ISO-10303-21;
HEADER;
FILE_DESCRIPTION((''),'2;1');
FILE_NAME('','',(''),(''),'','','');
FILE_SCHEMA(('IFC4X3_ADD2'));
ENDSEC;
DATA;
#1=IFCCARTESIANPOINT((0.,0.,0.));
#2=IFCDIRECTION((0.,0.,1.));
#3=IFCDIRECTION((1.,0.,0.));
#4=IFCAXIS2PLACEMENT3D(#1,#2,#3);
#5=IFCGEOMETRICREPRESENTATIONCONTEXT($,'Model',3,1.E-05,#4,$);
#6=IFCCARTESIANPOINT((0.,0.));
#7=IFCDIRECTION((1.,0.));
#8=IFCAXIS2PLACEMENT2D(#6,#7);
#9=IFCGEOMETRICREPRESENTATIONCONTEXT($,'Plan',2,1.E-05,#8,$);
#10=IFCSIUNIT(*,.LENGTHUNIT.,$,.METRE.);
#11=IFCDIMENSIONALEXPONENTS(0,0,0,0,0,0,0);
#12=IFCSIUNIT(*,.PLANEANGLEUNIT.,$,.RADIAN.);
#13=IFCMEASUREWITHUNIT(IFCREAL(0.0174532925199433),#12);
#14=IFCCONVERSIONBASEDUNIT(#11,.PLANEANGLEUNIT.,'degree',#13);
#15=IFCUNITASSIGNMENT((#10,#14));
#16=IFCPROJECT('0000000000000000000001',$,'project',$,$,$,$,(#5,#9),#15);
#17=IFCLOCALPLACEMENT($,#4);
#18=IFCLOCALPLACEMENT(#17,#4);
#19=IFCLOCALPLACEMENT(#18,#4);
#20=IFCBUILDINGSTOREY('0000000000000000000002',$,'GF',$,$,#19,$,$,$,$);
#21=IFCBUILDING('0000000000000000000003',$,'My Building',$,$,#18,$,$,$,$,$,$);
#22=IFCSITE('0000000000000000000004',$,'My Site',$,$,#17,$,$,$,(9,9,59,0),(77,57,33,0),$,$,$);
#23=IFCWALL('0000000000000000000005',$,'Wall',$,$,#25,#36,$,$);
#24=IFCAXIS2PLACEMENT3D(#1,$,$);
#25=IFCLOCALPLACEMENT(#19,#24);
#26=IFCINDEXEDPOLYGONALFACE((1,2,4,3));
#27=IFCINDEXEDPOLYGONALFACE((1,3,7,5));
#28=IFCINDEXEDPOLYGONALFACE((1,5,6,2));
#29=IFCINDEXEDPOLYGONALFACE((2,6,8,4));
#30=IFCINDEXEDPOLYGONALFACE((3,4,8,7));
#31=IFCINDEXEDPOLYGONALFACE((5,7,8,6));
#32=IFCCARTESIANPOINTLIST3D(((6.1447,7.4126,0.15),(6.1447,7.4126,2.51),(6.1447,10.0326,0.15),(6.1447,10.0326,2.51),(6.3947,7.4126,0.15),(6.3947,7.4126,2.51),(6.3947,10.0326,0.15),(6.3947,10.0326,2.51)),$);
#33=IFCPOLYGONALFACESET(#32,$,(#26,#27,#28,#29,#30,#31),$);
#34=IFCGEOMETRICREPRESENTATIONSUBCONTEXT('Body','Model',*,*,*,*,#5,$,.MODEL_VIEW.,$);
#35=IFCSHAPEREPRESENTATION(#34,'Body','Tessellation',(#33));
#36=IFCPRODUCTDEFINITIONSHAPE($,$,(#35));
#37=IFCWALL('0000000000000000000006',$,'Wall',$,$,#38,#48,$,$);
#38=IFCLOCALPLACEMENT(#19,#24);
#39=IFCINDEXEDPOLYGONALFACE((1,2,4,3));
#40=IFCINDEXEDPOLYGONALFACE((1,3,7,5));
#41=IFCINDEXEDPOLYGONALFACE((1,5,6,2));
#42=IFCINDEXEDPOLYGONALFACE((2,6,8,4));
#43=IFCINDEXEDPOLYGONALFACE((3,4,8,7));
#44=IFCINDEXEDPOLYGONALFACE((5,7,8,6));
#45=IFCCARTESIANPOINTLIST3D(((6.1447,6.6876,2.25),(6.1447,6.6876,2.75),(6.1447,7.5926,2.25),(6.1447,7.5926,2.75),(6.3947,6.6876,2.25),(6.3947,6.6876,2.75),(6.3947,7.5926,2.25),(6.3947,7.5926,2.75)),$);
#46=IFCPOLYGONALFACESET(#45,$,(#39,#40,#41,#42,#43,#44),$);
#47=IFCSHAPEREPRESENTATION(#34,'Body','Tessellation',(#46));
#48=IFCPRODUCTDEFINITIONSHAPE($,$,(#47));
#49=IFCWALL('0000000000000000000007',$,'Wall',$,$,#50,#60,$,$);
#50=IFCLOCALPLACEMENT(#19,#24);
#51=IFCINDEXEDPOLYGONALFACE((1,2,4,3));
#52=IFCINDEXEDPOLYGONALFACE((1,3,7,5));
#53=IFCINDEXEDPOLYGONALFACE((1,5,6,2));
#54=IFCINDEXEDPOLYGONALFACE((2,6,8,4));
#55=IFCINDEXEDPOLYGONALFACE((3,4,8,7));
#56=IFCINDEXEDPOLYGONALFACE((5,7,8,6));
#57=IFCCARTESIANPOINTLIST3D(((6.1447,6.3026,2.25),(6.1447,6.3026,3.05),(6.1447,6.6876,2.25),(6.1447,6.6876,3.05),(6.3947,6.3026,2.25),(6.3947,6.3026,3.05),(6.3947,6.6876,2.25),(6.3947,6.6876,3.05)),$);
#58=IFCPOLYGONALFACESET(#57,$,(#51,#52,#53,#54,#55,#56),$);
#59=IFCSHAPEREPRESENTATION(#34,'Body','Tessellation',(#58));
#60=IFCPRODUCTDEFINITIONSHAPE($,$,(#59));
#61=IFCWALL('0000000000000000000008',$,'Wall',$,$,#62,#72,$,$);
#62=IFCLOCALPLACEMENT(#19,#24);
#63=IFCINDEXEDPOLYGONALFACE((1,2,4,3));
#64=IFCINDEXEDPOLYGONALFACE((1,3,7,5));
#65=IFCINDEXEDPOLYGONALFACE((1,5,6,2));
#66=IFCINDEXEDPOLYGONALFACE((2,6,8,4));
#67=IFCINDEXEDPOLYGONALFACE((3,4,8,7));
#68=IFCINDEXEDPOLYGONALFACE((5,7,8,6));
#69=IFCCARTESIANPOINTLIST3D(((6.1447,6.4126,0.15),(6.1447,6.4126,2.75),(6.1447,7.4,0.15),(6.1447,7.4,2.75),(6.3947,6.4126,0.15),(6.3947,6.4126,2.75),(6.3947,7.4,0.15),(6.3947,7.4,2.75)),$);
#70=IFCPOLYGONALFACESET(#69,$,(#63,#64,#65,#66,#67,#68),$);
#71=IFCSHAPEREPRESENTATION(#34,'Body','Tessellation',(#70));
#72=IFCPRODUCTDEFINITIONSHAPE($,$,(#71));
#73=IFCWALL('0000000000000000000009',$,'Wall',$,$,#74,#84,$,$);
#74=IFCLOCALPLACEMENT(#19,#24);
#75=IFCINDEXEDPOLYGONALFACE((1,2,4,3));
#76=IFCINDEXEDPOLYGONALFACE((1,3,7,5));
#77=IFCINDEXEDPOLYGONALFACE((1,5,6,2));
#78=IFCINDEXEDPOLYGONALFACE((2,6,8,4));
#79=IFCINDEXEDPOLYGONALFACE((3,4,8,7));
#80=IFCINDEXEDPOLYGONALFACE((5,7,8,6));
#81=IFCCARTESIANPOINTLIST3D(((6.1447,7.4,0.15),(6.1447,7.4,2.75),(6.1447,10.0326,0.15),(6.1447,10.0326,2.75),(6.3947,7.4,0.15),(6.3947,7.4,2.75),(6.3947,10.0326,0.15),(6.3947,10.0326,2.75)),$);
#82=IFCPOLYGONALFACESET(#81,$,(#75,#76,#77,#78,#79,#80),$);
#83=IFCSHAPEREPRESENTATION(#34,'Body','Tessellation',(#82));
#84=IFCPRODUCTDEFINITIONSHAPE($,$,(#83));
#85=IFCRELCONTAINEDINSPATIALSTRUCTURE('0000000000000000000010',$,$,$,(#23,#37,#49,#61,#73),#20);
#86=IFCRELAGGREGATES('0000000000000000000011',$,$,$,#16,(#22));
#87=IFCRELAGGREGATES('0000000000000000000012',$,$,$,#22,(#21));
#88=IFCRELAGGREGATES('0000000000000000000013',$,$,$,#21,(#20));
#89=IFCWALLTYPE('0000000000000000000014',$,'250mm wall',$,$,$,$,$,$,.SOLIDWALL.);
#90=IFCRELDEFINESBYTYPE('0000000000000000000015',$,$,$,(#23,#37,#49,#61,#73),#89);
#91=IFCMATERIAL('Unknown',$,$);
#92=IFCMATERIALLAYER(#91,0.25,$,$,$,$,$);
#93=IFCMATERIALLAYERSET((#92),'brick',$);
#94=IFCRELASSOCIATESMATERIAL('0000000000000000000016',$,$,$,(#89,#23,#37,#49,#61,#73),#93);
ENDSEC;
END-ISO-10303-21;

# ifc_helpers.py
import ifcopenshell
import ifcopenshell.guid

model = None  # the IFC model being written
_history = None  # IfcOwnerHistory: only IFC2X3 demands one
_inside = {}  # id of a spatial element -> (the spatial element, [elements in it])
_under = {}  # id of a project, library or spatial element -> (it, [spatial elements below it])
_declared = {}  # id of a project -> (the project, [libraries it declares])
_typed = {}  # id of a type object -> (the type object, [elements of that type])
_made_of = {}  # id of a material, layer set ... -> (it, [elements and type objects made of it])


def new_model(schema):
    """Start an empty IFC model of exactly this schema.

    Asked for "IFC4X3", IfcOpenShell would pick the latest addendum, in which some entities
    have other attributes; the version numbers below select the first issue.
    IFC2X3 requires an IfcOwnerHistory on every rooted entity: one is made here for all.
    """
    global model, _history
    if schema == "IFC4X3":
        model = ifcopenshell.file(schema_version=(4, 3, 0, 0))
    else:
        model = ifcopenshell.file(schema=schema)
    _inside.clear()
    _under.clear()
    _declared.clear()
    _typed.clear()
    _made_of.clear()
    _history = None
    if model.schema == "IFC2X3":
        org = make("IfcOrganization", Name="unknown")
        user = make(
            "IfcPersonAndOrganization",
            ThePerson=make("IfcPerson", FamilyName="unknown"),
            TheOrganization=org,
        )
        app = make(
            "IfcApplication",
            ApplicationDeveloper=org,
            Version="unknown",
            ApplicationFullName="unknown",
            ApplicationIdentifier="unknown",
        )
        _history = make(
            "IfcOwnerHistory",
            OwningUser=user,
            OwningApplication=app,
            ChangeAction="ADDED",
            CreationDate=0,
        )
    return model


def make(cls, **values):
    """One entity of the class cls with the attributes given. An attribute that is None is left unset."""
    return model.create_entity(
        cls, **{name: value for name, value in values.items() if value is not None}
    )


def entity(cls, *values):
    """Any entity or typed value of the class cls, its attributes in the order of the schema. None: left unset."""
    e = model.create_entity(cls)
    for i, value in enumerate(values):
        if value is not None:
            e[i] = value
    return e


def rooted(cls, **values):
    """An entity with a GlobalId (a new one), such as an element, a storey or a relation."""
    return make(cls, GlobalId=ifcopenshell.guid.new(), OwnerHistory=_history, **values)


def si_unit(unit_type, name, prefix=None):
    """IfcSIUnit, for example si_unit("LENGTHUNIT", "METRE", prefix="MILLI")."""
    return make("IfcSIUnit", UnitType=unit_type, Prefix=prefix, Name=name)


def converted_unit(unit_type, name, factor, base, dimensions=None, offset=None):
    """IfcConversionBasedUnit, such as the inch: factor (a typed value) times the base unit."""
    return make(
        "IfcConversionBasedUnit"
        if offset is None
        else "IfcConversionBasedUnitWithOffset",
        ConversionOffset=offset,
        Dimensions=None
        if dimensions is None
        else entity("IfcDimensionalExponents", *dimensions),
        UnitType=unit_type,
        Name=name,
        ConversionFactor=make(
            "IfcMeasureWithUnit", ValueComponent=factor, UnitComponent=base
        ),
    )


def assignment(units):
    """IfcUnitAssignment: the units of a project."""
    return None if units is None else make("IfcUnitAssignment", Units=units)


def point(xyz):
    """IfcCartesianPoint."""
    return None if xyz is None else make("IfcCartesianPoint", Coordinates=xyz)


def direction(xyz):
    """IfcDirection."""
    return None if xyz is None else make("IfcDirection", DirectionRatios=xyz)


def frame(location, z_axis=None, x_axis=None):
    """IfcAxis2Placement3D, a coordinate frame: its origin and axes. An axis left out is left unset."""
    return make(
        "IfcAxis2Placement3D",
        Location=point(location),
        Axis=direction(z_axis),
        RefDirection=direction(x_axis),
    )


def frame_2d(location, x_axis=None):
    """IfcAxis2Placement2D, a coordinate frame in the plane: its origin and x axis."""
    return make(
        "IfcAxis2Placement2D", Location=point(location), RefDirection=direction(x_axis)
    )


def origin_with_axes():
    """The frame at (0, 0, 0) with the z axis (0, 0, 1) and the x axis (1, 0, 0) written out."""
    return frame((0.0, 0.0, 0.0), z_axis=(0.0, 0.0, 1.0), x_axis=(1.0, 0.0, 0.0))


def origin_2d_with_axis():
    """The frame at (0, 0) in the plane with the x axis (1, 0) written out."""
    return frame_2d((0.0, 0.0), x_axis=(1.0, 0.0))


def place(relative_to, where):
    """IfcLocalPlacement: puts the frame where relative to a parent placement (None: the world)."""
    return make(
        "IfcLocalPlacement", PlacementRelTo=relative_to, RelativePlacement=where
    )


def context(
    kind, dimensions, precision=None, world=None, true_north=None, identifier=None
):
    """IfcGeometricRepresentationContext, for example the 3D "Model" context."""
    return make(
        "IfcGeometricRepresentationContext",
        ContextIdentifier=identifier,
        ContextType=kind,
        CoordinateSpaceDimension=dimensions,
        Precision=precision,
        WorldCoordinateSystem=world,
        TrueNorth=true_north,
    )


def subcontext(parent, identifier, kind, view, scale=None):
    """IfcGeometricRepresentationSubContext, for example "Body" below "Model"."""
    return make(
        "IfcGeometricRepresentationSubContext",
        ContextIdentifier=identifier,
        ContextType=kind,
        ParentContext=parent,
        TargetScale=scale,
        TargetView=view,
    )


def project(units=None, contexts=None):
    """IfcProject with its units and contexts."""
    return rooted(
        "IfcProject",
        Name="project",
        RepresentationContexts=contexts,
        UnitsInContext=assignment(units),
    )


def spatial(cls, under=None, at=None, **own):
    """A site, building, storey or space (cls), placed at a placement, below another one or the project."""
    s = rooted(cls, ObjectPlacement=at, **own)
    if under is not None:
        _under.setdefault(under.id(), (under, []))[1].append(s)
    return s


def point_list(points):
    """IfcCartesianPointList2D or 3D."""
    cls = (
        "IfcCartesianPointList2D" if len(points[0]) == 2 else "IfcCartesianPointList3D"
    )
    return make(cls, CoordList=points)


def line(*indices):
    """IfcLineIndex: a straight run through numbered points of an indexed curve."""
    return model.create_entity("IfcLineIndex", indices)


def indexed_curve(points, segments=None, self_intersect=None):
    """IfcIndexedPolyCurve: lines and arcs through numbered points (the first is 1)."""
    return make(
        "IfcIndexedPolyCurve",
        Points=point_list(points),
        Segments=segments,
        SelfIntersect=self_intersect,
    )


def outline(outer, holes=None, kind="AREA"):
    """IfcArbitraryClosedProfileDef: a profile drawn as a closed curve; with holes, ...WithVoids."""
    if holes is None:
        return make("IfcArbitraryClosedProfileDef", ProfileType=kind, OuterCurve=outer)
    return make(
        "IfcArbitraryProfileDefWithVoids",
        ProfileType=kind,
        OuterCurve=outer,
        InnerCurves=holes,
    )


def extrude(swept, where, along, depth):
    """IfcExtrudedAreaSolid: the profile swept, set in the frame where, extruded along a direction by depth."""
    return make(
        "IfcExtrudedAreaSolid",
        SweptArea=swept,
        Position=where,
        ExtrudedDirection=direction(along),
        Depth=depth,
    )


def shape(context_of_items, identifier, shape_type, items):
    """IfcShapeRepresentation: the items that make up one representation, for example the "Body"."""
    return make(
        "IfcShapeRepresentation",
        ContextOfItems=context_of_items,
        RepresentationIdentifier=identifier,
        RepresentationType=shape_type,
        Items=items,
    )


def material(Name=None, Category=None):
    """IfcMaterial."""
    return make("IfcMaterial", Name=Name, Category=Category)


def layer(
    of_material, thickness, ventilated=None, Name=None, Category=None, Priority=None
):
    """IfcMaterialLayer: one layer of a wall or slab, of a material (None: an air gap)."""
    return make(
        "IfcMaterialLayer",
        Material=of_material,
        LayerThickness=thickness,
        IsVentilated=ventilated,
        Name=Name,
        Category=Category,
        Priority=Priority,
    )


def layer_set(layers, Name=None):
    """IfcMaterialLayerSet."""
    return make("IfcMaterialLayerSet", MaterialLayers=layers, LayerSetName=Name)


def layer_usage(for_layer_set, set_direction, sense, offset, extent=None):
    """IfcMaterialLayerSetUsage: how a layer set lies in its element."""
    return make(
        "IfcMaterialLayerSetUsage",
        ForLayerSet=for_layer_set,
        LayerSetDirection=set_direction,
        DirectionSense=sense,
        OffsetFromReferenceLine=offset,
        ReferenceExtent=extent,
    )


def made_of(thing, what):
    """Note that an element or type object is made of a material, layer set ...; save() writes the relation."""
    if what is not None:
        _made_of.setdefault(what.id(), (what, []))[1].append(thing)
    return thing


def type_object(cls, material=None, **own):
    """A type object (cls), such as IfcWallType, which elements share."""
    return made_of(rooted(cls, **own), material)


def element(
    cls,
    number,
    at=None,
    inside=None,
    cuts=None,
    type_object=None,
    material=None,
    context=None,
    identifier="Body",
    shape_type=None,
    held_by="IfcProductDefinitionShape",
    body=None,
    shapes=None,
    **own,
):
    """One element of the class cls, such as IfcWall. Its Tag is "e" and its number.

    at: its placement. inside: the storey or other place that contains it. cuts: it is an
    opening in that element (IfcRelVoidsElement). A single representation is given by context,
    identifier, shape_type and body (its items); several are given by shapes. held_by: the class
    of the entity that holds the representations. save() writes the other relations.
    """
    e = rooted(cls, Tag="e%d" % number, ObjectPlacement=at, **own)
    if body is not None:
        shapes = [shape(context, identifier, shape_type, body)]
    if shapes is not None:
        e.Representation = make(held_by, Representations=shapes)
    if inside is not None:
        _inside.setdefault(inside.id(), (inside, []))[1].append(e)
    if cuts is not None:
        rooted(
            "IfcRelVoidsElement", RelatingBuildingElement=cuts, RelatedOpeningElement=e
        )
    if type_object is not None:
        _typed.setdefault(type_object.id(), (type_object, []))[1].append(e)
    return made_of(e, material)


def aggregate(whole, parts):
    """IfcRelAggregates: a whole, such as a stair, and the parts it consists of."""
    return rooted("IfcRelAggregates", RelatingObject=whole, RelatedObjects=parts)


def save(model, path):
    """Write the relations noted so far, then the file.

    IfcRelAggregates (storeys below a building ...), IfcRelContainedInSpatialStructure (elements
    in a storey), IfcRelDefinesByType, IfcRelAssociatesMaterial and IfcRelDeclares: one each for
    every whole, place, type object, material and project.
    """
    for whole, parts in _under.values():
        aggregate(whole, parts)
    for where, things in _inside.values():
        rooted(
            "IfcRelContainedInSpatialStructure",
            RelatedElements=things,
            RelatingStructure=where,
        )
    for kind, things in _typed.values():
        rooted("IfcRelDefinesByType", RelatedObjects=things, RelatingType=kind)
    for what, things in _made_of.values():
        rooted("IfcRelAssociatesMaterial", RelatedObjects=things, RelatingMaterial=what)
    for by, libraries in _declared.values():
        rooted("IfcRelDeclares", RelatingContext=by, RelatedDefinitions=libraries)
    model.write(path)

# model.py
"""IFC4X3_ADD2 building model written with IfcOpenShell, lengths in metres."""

from ifc_helpers import new_model, entity, si_unit, converted_unit, frame, origin_with_axes, origin_2d_with_axis, place, context, subcontext, project, spatial, line, indexed_curve, outline, extrude, material, layer, layer_set, layer_usage, type_object, element, save


model = new_model("IFC4X3_ADD2")

# Units and contexts
model_context = context("Model", 3, precision=1e-05, world=origin_with_axes())
plan_context = context("Plan", 2, precision=1e-05, world=origin_2d_with_axis())
body_context_1 = subcontext(model_context, "Body", "Model", "MODEL_VIEW")
ifc_project = project(units=[si_unit("LENGTHUNIT", "METRE"), converted_unit("PLANEANGLEUNIT", "degree", entity("IfcReal", 0.0174532925199433), si_unit("PLANEANGLEUNIT", "RADIAN"), dimensions=[0, 0, 0, 0, 0, 0, 0])], contexts=[model_context, plan_context])

# Site, building, storey
site_placement = place(None, origin_with_axes())
site = spatial("IfcSite", under=ifc_project, at=site_placement, Name="My Site", RefLatitude=(9, 9, 59, 0), RefLongitude=(77, 57, 33, 0))
building_placement = place(site_placement, origin_with_axes())
building = spatial("IfcBuilding", under=site, at=building_placement, Name="My Building")
storey_placement = place(building_placement, origin_with_axes())
storey = spatial("IfcBuildingStorey", under=building, at=storey_placement, Name="GF")

# Walls
ifc_material_1 = material(Name="Unknown")
ifc_layer_1 = layer(ifc_material_1, 0.25)
ifc_layer_set_1 = layer_set([ifc_layer_1], Name="brick")
ifc_layer_usage_1 = layer_usage(ifc_layer_set_1, "AXIS2", "POSITIVE", 0.0)
wall_type_1 = type_object("IfcWallType", Name="250mm wall", PredefinedType="SOLIDWALL", material=ifc_layer_set_1)
wall_1_placement = place(storey_placement, frame((6.3947, 7.4126, 0.15), z_axis=(0.0, 0.0, 1.0), x_axis=(0.0, 1.0, 0.0)))
element("IfcWall", 1, at=wall_1_placement, inside=storey, type_object=wall_type_1, material=ifc_layer_usage_1, Name="Wall", context=body_context_1, shape_type="SweptSolid", body=[
    extrude(outline(indexed_curve([(0.0, 0.0), (0.0, 0.25), (2.62, 0.25), (2.62, 0.0)], segments=[line(1, 2, 3, 4, 1)])), origin_with_axes(), (0.0, 0.0, 1.0), 2.36),
])
ifc_layer_usage_2 = layer_usage(ifc_layer_set_1, "AXIS2", "POSITIVE", 0.0)
wall_2_placement = place(storey_placement, frame((6.3947, 6.6876, 2.25), z_axis=(0.0, 0.0, 1.0), x_axis=(0.0, 1.0, 0.0)))
element("IfcWall", 2, at=wall_2_placement, inside=storey, type_object=wall_type_1, material=ifc_layer_usage_2, Name="Wall", context=body_context_1, shape_type="SweptSolid", body=[
    extrude(outline(indexed_curve([(0.0, 0.0), (0.0, 0.25), (0.905, 0.25), (0.905, 0.0)], segments=[line(1, 2, 3, 4, 1)])), origin_with_axes(), (0.0, 0.0, 1.0), 0.5),
])
ifc_layer_usage_3 = layer_usage(ifc_layer_set_1, "AXIS2", "POSITIVE", 0.0)
wall_3_placement = place(storey_placement, frame((6.3947, 6.3026, 2.25), z_axis=(0.0, 0.0, 1.0), x_axis=(0.0, 1.0, 0.0)))
element("IfcWall", 3, at=wall_3_placement, inside=storey, type_object=wall_type_1, material=ifc_layer_usage_3, Name="Wall", context=body_context_1, shape_type="SweptSolid", body=[
    extrude(outline(indexed_curve([(0.0, 0.0), (0.0, 0.25), (0.385, 0.25), (0.385, 0.0)], segments=[line(1, 2, 3, 4, 1)])), origin_with_axes(), (0.0, 0.0, 1.0), 0.8),
])
ifc_layer_usage_4 = layer_usage(ifc_layer_set_1, "AXIS2", "POSITIVE", 0.0)
wall_4_placement = place(storey_placement, frame((6.3947, 6.4126, 0.15), z_axis=(0.0, 0.0, 1.0), x_axis=(0.0, 1.0, 0.0)))
element("IfcWall", 4, at=wall_4_placement, inside=storey, type_object=wall_type_1, material=ifc_layer_usage_4, Name="Wall", context=body_context_1, shape_type="SweptSolid", body=[
    extrude(outline(indexed_curve([(0.0, 0.0), (0.0, 0.25), (0.9874, 0.25), (0.9874, 0.0)], segments=[line(1, 2, 3, 4, 1)])), origin_with_axes(), (0.0, 0.0, 1.0), 2.6),
])
ifc_layer_usage_5 = layer_usage(ifc_layer_set_1, "AXIS2", "POSITIVE", 0.0)
wall_5_placement = place(storey_placement, frame((6.3947, 7.4, 0.15), z_axis=(0.0, 0.0, 1.0), x_axis=(0.0, 1.0, 0.0)))
element("IfcWall", 5, at=wall_5_placement, inside=storey, type_object=wall_type_1, material=ifc_layer_usage_5, Name="Wall", context=body_context_1, shape_type="SweptSolid", body=[
    extrude(outline(indexed_curve([(0.0, 0.0), (0.0, 0.25), (2.6326, 0.25), (2.6326, 0.0)], segments=[line(1, 2, 3, 4, 1)])), origin_with_axes(), (0.0, 0.0, 1.0), 2.6),
])

save(model, "model.ifc")
